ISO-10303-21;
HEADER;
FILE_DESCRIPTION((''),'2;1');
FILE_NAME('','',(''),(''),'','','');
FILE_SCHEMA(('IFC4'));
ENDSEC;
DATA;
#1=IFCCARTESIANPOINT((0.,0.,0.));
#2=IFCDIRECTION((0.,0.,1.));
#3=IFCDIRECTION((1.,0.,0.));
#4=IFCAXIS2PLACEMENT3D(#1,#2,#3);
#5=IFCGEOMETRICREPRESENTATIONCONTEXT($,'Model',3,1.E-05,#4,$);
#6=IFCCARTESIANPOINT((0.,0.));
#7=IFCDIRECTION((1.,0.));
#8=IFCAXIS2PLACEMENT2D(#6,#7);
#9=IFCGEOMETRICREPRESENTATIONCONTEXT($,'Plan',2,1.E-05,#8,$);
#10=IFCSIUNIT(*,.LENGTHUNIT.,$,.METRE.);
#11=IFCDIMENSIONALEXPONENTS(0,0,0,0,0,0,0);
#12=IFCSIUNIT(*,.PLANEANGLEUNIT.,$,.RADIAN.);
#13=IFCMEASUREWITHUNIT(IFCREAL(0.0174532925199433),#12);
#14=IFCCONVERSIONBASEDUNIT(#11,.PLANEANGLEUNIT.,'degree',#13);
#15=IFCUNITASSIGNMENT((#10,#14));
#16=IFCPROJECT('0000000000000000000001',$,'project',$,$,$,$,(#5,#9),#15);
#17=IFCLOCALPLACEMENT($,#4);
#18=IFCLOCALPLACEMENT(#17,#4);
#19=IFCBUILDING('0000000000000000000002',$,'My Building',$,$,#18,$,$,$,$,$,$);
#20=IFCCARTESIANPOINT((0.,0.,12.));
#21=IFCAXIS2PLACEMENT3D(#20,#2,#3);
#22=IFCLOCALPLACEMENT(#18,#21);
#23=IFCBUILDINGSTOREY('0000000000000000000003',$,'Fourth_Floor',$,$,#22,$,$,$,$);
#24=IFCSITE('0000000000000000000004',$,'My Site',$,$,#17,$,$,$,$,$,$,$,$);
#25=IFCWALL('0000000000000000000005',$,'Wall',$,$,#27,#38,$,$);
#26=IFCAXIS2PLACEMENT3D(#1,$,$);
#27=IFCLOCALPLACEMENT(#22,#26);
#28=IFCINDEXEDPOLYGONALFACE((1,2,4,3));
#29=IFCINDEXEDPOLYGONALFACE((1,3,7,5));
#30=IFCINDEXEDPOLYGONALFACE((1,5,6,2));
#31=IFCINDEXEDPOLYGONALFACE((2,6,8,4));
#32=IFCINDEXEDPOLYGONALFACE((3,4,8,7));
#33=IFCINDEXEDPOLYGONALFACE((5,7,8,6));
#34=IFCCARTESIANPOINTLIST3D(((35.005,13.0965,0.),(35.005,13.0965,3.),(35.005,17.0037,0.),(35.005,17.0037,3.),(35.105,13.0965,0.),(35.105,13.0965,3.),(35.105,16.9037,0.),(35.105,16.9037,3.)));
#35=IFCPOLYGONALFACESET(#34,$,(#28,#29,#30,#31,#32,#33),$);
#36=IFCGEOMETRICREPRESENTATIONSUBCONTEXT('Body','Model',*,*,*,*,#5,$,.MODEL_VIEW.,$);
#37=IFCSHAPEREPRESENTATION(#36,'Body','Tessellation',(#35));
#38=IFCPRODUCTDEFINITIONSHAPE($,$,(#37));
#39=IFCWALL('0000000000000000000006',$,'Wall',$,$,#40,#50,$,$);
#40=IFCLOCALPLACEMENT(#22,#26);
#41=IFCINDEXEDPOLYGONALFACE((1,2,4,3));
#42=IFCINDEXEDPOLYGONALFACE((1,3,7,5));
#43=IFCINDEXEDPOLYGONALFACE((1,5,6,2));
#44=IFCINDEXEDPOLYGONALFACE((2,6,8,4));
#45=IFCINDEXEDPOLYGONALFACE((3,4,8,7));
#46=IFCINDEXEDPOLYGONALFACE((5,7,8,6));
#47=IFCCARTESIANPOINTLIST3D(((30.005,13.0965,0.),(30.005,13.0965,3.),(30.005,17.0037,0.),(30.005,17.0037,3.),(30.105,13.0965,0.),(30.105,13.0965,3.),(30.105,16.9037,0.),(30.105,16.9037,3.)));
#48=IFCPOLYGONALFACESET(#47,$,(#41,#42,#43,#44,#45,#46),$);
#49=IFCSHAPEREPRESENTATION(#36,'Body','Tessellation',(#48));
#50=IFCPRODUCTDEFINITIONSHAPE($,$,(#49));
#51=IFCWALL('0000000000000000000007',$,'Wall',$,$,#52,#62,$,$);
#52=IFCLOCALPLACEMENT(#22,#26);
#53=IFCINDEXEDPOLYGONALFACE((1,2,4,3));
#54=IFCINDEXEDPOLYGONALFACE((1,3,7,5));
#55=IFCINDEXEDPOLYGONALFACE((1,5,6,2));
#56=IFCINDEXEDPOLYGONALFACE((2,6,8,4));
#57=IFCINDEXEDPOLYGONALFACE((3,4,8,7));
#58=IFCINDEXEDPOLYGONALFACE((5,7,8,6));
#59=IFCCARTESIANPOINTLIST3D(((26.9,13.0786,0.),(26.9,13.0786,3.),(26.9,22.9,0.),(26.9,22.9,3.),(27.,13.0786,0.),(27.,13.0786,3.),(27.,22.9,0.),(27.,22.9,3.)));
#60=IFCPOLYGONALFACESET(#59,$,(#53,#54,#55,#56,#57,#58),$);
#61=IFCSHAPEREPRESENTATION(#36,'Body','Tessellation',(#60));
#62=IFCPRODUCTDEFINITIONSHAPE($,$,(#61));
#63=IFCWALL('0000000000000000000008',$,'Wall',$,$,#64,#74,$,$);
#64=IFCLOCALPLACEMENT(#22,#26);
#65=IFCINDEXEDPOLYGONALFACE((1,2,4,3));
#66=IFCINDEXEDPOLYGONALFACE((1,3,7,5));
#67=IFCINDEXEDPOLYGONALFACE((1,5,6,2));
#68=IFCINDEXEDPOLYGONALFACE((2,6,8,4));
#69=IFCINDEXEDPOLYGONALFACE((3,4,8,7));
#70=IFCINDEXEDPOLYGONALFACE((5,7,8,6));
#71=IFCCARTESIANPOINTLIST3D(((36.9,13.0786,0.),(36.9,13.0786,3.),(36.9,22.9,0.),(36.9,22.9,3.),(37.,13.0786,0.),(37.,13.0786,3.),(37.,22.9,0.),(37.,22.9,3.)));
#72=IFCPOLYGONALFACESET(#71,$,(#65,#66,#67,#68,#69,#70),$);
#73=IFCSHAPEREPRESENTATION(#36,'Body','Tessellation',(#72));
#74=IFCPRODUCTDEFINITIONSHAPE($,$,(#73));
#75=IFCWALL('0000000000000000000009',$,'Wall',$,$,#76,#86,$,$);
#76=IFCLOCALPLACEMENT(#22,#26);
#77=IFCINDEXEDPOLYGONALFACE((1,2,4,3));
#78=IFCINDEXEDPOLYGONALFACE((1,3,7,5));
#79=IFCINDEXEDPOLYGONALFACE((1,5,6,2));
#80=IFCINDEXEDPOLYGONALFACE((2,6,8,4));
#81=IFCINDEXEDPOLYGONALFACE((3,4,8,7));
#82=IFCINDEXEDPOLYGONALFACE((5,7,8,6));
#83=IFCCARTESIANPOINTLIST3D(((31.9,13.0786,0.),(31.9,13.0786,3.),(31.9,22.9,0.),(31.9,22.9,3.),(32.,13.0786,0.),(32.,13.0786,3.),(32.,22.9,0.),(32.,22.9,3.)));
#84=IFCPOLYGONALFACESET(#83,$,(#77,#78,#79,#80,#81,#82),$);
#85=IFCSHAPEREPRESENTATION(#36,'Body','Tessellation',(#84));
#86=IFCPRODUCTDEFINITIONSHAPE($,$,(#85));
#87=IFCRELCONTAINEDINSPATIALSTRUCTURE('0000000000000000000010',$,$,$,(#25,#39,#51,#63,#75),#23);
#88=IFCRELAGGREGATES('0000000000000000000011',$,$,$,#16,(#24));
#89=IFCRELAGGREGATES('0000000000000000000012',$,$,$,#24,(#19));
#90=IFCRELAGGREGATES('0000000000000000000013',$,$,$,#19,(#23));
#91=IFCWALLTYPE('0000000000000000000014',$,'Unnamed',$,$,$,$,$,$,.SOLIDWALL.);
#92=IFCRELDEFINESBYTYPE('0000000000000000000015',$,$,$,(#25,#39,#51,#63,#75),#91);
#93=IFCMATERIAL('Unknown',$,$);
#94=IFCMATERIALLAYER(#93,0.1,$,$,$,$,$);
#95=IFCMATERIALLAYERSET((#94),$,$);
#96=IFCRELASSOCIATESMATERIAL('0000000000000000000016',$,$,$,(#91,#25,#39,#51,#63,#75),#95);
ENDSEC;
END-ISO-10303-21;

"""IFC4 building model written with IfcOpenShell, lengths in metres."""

from ifc_helpers import new_model, entity, si_unit, converted_unit, frame, origin_with_axes, origin_2d_with_axis, place, context, subcontext, project, spatial, line, indexed_curve, outline, extrude, material, layer, layer_set, layer_usage, type_object, element, save


model = new_model("IFC4")

# Units and contexts
model_context = context("Model", 3, precision=1e-05, world=origin_with_axes())
plan_context = context("Plan", 2, precision=1e-05, world=origin_2d_with_axis())
body_context_1 = subcontext(model_context, "Body", "Model", "MODEL_VIEW")
ifc_project = project(units=[si_unit("LENGTHUNIT", "METRE"), converted_unit("PLANEANGLEUNIT", "degree", entity("IfcReal", 0.0174532925199433), si_unit("PLANEANGLEUNIT", "RADIAN"), dimensions=[0, 0, 0, 0, 0, 0, 0])], contexts=[model_context, plan_context])

# Site, building, storey
site_placement = place(None, origin_with_axes())
site = spatial("IfcSite", under=ifc_project, at=site_placement, Name="My Site")
building_placement = place(site_placement, origin_with_axes())
building = spatial("IfcBuilding", under=site, at=building_placement, Name="My Building")
storey_placement = place(building_placement, frame((0.0, 0.0, 12.0), z_axis=(0.0, 0.0, 1.0), x_axis=(1.0, 0.0, 0.0)))
storey = spatial("IfcBuildingStorey", under=building, at=storey_placement, Name="Fourth_Floor")

# Walls
ifc_material = material(Name="Unknown")
ifc_layer = layer(ifc_material, 0.1)
ifc_layer_set = layer_set([ifc_layer])
ifc_layer_usage_1 = layer_usage(ifc_layer_set, "AXIS2", "POSITIVE", 0.0)
wall_type = type_object("IfcWallType", Name="Unnamed", PredefinedType="SOLIDWALL", material=ifc_layer_set)
wall_1_placement = place(storey_placement, frame((35.005, 17.0037, 0.0), z_axis=(0.0, 0.0, 1.0), x_axis=(0.0, -1.0, 0.0)))
element("IfcWall", 1, at=wall_1_placement, inside=storey, type_object=wall_type, material=ifc_layer_usage_1, Name="Wall", context=body_context_1, shape_type="SweptSolid", body=[
    extrude(outline(indexed_curve([(0.0, 0.0), (0.1, 0.1), (3.9072, 0.1), (3.9072, 0.0)], segments=[line(1, 2, 3, 4, 1)])), origin_with_axes(), (0.0, 0.0, 1.0), 3.0),
])
ifc_layer_usage_2 = layer_usage(ifc_layer_set, "AXIS2", "POSITIVE", 0.0)
wall_2_placement = place(storey_placement, frame((30.005, 17.0037, 0.0), z_axis=(0.0, 0.0, 1.0), x_axis=(0.0, -1.0, 0.0)))
element("IfcWall", 2, at=wall_2_placement, inside=storey, type_object=wall_type, material=ifc_layer_usage_2, Name="Wall", context=body_context_1, shape_type="SweptSolid", body=[
    extrude(outline(indexed_curve([(0.0, 0.0), (0.1, 0.1), (3.9072, 0.1), (3.9072, 0.0)], segments=[line(1, 2, 3, 4, 1)])), origin_with_axes(), (0.0, 0.0, 1.0), 3.0),
])
ifc_layer_usage_3 = layer_usage(ifc_layer_set, "AXIS2", "POSITIVE", 0.0)
wall_3_placement = place(storey_placement, frame((26.9, 22.9, 0.0), z_axis=(0.0, 0.0, 1.0), x_axis=(0.0, -1.0, 0.0)))
element("IfcWall", 3, at=wall_3_placement, inside=storey, type_object=wall_type, material=ifc_layer_usage_3, Name="Wall", context=body_context_1, shape_type="SweptSolid", body=[
    extrude(outline(indexed_curve([(0.0, 0.0), (0.0, 0.1), (9.8214, 0.1), (9.8214, 0.0)], segments=[line(1, 2, 3, 4, 1)])), origin_with_axes(), (0.0, 0.0, 1.0), 3.0),
])
ifc_layer_usage_4 = layer_usage(ifc_layer_set, "AXIS2", "POSITIVE", 0.0)
wall_4_placement = place(storey_placement, frame((36.9, 22.9, 0.0), z_axis=(0.0, 0.0, 1.0), x_axis=(0.0, -1.0, 0.0)))
element("IfcWall", 4, at=wall_4_placement, inside=storey, type_object=wall_type, material=ifc_layer_usage_4, Name="Wall", context=body_context_1, shape_type="SweptSolid", body=[
    extrude(outline(indexed_curve([(0.0, 0.0), (0.0, 0.1), (9.8214, 0.1), (9.8214, 0.0)], segments=[line(1, 2, 3, 4, 1)])), origin_with_axes(), (0.0, 0.0, 1.0), 3.0),
])
ifc_layer_usage_5 = layer_usage(ifc_layer_set, "AXIS2", "POSITIVE", 0.0)
wall_5_placement = place(storey_placement, frame((31.9, 22.9, 0.0), z_axis=(0.0, 0.0, 1.0), x_axis=(0.0, -1.0, 0.0)))
element("IfcWall", 5, at=wall_5_placement, inside=storey, type_object=wall_type, material=ifc_layer_usage_5, Name="Wall", context=body_context_1, shape_type="SweptSolid", body=[
    extrude(outline(indexed_curve([(0.0, 0.0), (0.0, 0.1), (9.8214, 0.1), (9.8214, 0.0)], segments=[line(1, 2, 3, 4, 1)])), origin_with_axes(), (0.0, 0.0, 1.0), 3.0),
])

save(model, "model.ifc")
